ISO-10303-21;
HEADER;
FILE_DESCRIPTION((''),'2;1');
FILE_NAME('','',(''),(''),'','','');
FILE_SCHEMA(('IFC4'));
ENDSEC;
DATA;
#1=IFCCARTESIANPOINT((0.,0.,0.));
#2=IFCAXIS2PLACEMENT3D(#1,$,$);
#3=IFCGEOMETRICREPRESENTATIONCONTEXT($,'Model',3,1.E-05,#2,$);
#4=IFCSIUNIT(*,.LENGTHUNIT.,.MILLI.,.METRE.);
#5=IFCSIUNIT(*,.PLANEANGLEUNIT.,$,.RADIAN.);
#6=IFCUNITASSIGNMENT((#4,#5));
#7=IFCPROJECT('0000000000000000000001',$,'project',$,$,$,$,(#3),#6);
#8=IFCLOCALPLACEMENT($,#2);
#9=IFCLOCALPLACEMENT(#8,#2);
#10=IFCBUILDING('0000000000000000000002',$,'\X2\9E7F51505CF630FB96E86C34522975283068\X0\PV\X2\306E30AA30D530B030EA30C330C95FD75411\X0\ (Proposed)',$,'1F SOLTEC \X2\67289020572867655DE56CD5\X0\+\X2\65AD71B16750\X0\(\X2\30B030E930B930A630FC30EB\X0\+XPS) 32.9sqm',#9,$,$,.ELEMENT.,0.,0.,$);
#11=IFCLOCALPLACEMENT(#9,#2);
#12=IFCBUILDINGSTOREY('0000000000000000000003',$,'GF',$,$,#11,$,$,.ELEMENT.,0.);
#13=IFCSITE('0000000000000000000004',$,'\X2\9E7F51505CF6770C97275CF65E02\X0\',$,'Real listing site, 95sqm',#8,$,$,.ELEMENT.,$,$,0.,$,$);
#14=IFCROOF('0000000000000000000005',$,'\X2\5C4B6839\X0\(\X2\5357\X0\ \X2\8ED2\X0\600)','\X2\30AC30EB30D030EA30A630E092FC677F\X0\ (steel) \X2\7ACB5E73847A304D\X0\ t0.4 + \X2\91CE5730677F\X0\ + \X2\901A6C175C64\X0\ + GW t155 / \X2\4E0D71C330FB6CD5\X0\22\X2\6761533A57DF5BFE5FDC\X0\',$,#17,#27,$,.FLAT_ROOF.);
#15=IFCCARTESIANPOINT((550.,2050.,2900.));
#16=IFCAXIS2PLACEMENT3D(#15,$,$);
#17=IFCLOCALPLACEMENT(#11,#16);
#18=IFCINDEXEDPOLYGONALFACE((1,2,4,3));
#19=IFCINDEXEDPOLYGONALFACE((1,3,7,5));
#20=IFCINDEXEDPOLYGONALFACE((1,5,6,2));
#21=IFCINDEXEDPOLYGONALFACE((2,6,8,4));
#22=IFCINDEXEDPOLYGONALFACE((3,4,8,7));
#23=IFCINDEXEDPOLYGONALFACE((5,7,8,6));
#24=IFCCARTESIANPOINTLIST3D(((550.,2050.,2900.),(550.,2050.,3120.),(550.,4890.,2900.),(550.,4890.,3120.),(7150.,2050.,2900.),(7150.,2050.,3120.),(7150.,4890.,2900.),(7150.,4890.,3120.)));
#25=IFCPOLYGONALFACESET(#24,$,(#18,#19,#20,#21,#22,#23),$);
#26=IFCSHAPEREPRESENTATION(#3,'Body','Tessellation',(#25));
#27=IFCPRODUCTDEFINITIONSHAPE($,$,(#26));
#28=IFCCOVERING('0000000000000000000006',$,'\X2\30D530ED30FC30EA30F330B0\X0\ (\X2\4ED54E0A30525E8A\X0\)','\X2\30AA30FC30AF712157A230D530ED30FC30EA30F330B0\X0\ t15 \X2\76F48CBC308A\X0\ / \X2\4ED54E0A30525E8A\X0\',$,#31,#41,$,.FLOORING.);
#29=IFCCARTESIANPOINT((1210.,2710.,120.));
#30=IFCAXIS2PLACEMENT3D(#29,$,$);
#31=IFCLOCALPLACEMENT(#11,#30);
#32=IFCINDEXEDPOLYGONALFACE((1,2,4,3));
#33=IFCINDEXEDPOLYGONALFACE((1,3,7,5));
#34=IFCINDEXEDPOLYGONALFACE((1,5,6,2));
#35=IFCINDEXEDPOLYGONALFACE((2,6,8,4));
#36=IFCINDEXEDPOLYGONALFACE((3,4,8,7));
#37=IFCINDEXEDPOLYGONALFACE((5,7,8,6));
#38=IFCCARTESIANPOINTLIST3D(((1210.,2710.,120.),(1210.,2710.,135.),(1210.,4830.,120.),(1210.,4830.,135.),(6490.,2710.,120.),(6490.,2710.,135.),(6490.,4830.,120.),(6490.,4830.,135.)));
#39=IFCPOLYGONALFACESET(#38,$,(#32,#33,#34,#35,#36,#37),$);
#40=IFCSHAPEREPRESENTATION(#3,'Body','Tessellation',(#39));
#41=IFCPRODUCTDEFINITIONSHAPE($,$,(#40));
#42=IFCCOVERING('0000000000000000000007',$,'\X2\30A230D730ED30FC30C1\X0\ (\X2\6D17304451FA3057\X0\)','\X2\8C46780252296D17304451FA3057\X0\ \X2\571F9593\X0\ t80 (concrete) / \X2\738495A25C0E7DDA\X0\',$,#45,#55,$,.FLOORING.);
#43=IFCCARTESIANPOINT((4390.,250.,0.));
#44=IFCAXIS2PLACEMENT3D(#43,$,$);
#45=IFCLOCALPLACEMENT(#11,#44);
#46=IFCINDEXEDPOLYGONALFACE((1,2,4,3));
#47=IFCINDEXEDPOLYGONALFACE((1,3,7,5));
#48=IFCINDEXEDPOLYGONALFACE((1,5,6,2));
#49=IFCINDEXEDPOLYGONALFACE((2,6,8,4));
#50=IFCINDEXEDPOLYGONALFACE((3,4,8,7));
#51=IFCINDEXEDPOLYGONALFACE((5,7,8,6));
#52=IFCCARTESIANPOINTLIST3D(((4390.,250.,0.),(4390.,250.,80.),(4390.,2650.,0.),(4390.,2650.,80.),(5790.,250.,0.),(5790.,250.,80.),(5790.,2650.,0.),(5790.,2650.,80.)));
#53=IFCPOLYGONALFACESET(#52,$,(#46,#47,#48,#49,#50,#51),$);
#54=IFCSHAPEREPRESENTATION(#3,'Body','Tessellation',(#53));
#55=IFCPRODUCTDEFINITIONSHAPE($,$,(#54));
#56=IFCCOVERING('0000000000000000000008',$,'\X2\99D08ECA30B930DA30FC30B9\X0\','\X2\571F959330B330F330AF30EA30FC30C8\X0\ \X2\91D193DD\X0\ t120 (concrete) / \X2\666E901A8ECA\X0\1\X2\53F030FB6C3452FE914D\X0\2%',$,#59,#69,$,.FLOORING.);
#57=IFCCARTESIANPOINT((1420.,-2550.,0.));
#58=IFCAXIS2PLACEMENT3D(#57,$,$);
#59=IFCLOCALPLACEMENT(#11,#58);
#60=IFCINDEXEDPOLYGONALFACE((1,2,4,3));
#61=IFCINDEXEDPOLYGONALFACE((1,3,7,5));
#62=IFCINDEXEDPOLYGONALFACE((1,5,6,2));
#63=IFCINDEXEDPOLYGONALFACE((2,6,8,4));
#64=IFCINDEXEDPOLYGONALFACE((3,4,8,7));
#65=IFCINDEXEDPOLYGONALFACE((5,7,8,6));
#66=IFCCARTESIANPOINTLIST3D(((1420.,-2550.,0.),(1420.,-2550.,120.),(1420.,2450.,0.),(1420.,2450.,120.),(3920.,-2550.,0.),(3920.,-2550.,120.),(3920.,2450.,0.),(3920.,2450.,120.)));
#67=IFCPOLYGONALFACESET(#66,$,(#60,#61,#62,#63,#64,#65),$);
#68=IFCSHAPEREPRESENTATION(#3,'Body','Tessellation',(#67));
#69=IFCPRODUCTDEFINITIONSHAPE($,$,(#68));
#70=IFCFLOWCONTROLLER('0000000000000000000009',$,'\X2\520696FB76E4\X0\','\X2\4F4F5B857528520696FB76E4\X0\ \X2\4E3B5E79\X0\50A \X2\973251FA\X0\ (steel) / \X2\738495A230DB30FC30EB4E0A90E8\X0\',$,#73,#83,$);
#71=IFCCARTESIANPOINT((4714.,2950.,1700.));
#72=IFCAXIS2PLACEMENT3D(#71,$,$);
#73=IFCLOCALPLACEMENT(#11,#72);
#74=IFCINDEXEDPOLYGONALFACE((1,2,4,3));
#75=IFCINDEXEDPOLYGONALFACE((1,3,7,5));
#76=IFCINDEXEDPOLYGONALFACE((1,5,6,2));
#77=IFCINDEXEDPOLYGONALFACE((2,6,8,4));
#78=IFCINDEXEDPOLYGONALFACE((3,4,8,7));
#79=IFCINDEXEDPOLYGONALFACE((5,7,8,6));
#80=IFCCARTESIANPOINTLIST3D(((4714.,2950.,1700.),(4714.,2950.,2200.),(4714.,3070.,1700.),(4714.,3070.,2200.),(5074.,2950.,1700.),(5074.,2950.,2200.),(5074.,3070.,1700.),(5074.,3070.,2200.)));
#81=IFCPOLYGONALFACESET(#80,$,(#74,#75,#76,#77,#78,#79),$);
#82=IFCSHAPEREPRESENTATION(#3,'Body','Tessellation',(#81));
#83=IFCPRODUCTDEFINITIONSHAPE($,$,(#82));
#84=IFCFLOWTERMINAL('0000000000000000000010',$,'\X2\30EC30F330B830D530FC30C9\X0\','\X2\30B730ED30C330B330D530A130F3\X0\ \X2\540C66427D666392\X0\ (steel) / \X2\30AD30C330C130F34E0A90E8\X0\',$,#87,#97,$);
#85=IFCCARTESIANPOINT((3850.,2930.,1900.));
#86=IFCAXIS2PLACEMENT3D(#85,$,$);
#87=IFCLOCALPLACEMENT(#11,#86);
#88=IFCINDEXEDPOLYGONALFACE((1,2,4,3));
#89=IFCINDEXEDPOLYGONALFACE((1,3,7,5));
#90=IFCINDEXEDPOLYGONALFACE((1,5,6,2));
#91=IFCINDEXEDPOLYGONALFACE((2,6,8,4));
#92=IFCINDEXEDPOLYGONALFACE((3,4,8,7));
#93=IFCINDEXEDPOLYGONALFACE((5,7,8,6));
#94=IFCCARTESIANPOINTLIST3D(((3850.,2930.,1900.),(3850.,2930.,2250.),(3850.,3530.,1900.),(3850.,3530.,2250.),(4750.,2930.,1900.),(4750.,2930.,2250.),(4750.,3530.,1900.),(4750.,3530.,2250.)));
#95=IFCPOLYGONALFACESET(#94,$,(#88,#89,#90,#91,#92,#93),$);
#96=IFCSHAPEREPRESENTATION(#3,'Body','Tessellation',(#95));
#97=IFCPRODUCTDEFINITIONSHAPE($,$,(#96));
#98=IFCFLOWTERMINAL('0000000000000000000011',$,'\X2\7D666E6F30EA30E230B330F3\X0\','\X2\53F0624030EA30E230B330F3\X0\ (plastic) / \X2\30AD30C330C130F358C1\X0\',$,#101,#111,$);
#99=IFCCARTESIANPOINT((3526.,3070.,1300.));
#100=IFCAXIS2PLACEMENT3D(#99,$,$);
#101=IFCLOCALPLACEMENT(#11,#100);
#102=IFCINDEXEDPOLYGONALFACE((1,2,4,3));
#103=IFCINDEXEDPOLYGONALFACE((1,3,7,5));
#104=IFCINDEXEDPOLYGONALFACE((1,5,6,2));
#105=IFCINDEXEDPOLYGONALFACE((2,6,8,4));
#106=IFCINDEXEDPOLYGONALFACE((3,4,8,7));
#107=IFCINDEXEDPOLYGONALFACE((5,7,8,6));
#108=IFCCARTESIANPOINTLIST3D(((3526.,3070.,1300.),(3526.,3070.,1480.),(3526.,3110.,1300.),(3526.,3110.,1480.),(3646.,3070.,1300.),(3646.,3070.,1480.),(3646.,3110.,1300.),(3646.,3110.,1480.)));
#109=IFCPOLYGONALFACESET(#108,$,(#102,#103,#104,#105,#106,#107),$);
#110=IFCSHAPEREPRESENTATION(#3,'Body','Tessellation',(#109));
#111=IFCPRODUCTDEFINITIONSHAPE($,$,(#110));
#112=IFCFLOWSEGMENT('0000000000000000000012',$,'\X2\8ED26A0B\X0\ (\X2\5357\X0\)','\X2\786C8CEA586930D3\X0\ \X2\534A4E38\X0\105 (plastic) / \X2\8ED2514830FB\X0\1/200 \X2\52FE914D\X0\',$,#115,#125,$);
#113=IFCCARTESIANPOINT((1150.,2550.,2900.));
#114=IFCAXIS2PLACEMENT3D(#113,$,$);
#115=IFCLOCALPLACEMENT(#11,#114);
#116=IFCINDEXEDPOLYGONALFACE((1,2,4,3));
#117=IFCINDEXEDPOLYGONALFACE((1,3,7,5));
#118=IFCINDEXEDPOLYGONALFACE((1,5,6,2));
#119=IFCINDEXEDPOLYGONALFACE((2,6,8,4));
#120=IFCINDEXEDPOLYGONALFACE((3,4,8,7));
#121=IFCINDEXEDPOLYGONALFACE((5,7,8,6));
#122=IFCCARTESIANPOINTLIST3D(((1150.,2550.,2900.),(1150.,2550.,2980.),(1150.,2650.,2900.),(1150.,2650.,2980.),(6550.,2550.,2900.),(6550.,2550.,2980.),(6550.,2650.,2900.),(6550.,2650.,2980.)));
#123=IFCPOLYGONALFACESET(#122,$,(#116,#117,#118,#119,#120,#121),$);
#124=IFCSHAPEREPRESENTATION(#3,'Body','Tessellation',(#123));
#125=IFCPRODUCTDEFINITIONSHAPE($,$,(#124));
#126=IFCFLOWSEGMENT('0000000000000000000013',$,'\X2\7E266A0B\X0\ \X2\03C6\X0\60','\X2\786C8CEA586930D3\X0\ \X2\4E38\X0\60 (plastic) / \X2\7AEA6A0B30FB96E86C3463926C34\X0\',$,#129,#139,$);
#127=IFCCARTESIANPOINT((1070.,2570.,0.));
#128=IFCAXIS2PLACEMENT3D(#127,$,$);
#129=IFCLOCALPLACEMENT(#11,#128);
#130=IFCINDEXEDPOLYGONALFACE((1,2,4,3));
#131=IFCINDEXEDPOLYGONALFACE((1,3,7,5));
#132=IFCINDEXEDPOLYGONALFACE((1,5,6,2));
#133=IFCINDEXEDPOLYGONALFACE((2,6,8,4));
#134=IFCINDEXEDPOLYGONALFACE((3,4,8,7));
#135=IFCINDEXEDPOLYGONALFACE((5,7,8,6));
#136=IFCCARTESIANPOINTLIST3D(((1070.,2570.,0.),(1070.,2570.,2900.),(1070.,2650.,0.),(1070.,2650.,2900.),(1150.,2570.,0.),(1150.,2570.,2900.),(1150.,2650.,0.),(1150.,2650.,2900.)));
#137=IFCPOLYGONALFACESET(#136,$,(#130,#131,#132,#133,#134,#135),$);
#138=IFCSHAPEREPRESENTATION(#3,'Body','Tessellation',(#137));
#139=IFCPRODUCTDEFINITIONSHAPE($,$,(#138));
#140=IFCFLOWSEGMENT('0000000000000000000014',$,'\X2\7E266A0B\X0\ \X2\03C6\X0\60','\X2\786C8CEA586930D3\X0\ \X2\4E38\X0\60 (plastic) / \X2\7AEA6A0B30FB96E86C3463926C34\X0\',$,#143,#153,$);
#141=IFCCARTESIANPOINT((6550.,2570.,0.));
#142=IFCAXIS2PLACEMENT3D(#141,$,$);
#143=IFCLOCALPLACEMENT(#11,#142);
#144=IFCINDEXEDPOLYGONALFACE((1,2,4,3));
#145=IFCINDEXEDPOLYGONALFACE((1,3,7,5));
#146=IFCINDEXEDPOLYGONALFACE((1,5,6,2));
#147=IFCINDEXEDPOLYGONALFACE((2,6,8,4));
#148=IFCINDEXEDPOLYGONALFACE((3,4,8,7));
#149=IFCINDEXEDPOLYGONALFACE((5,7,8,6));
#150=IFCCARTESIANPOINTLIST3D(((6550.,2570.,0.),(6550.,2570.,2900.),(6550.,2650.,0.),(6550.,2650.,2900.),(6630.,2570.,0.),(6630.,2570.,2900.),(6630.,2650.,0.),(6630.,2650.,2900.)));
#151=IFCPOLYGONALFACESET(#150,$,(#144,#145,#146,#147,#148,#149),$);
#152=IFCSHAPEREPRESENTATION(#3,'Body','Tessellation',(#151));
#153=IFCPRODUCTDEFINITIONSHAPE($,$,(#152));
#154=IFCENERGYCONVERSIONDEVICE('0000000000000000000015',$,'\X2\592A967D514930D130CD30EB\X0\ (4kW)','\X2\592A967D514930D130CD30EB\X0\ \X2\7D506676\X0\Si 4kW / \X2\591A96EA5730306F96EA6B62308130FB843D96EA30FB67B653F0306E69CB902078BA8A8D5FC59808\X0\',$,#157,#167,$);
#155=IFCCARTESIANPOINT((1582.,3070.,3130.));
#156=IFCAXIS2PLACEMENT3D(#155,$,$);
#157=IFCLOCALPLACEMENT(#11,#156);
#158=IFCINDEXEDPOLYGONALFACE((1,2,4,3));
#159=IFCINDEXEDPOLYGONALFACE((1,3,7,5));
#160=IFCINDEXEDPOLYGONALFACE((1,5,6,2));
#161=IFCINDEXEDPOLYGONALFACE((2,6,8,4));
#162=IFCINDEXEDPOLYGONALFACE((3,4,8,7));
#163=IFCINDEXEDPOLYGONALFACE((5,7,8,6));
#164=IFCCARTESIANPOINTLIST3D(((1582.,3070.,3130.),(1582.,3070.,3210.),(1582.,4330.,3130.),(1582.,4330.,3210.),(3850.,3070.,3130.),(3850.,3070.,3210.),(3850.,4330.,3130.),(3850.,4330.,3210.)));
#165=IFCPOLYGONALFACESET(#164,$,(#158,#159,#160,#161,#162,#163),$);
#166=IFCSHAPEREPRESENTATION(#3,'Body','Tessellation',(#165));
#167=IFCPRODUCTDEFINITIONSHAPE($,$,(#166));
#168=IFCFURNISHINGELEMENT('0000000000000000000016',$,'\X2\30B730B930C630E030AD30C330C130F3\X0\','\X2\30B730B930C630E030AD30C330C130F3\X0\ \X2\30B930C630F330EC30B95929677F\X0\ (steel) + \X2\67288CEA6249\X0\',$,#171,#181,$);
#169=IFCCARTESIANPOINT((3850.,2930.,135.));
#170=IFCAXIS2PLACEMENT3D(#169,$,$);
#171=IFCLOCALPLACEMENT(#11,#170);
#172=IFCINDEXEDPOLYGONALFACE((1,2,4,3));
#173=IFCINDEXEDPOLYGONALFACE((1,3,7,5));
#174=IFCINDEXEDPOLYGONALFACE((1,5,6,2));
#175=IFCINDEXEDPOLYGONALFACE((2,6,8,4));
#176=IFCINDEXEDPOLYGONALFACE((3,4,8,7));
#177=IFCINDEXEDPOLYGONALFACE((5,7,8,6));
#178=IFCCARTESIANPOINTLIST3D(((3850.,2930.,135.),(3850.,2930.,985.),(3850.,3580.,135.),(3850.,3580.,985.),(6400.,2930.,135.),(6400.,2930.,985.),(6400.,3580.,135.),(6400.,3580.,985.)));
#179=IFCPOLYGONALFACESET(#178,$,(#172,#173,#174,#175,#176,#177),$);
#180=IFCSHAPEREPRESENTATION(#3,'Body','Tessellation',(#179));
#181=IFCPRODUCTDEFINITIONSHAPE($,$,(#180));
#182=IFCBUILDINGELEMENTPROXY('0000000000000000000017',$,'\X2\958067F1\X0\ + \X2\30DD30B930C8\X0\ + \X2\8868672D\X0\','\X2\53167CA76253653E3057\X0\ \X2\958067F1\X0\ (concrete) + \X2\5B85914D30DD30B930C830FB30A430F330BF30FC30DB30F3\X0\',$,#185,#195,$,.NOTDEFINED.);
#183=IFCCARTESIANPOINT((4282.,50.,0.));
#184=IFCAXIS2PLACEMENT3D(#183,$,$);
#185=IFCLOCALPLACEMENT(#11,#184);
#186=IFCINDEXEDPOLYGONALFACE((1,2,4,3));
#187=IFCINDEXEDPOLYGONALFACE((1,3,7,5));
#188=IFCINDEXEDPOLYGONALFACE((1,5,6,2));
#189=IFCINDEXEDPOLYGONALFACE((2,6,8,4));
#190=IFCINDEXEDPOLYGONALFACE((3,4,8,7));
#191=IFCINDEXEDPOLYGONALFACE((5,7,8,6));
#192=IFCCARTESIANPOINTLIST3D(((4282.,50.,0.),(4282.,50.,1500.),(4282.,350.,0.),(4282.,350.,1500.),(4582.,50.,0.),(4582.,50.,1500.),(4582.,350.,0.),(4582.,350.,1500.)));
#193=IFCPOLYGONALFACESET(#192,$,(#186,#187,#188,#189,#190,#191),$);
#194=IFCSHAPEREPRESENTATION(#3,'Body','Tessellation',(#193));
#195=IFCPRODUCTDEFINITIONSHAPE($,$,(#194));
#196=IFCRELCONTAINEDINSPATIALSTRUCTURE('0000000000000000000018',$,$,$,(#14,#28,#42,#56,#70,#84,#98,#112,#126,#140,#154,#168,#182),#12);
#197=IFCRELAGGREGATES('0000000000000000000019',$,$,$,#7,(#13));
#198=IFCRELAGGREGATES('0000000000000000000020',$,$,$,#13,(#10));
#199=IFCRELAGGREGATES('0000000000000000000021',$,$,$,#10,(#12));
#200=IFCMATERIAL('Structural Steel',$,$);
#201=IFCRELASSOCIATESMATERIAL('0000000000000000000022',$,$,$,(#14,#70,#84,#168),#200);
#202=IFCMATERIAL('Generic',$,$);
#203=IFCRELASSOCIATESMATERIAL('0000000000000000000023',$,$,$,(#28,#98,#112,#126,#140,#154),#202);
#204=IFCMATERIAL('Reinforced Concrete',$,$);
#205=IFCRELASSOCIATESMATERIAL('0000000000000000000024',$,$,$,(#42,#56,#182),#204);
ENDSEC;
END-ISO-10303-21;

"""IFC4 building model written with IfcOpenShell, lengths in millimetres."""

from ifc_helpers import new_model, si_unit, frame, frame_2d, origin, place, context, project, spatial, rectangle, extrude, material, element, save


model = new_model("IFC4")

# Units and contexts
model_context = context("Model", 3, precision=1e-05, world=origin())
ifc_project = project(units=[si_unit("LENGTHUNIT", "METRE", prefix="MILLI"), si_unit("PLANEANGLEUNIT", "RADIAN")], contexts=[model_context])

# Site, building, storey
site_placement = place(None, origin())
site = spatial("IfcSite", under=ifc_project, at=site_placement, Name="鹿児島県霧島市", ObjectType="Real listing site, 95sqm", CompositionType="ELEMENT", RefElevation=0.0)
building_placement = place(site_placement, origin())
building = spatial("IfcBuilding", under=site, at=building_placement, Name="鹿児島・雨水利用とPVのオフグリッド志向 (Proposed)", ObjectType="1F SOLTEC 木造在来工法+断熱材(グラスウール+XPS) 32.9sqm", CompositionType="ELEMENT", ElevationOfRefHeight=0.0, ElevationOfTerrain=0.0)
storey_placement = place(building_placement, origin())
storey = spatial("IfcBuildingStorey", under=building, at=storey_placement, Name="GF", CompositionType="ELEMENT", Elevation=0.0)

# Shared definitions
ifc_material_1 = material(Name="Reinforced Concrete")

# Roof
ifc_material_2 = material(Name="Structural Steel")
roof_placement = place(storey_placement, frame((550.0, 2050.0, 2900.0)))
element("IfcRoof", 1, at=roof_placement, inside=storey, material=ifc_material_2, Name="屋根(南 軒600)", Description="ガルバリウム鋼板 (steel) 立平葺き t0.4 + 野地板 + 通気層 + GW t155 / 不燃・法22条区域対応", PredefinedType="FLAT_ROOF", context=model_context, shape_type="SweptSolid", body=[
    extrude(rectangle(XDim=6600.0, YDim=2840.0, at=frame_2d((3300.0, 1420.0))), frame((550.0, 2050.0, 2900.0)), (0.0, 0.0, 1.0), 220.0),
])

# Coverings
ifc_material_3 = material(Name="Generic")
covering_1_placement = place(storey_placement, frame((1210.0, 2710.0, 120.0)))
element("IfcCovering", 2, at=covering_1_placement, inside=storey, material=ifc_material_3, Name="フローリング (仕上げ床)", Description="オーク無垢フローリング t15 直貼り / 仕上げ床", PredefinedType="FLOORING", context=model_context, shape_type="SweptSolid", body=[
    extrude(rectangle(XDim=5280.0, YDim=2120.0, at=frame_2d((2640.0, 1060.0))), frame((1210.0, 2710.0, 120.0)), (0.0, 0.0, 1.0), 15.0),
])
covering_2_placement = place(storey_placement, frame((4390.0, 250.0, 0.0)))
element("IfcCovering", 3, at=covering_2_placement, inside=storey, material=ifc_material_1, Name="アプローチ (洗い出し)", Description="豆砂利洗い出し 土間 t80 (concrete) / 玄関導線", PredefinedType="FLOORING", context=model_context, shape_type="SweptSolid", body=[
    extrude(rectangle(XDim=1400.0, YDim=2400.0, at=frame_2d((700.0, 1200.0))), frame((4390.0, 250.0, 0.0)), (0.0, 0.0, 1.0), 80.0),
])
covering_3_placement = place(storey_placement, frame((1420.0, -2550.0, 0.0)))
element("IfcCovering", 4, at=covering_3_placement, inside=storey, material=ifc_material_1, Name="駐車スペース", Description="土間コンクリート 金鏝 t120 (concrete) / 普通車1台・水勾配2%", PredefinedType="FLOORING", context=model_context, shape_type="SweptSolid", body=[
    extrude(rectangle(XDim=2500.0, YDim=5000.0, at=frame_2d((1250.0, 2500.0))), frame((1420.0, -2550.0, 0.0)), (0.0, 0.0, 1.0), 120.0),
])

# Flow controller
flow_controller_placement = place(storey_placement, frame((4714.0, 2950.0, 1700.0)))
element("IfcFlowController", 5, at=flow_controller_placement, inside=storey, material=ifc_material_2, Name="分電盤", Description="住宅用分電盤 主幹50A 露出 (steel) / 玄関ホール上部", context=model_context, shape_type="SweptSolid", body=[
    extrude(rectangle(XDim=360.0, YDim=120.0, at=frame_2d((180.0, 60.0))), frame((4714.0, 2950.0, 1700.0)), (0.0, 0.0, 1.0), 500.0),
])

# Flow terminals
flow_terminal_1_placement = place(storey_placement, frame((3850.0, 2930.0, 1900.0)))
element("IfcFlowTerminal", 6, at=flow_terminal_1_placement, inside=storey, material=ifc_material_2, Name="レンジフード", Description="シロッコファン 同時給排 (steel) / キッチン上部", context=model_context, shape_type="SweptSolid", body=[
    extrude(rectangle(XDim=900.0, YDim=600.0, at=frame_2d((450.0, 300.0))), frame((3850.0, 2930.0, 1900.0)), (0.0, 0.0, 1.0), 350.0),
])
flow_terminal_2_placement = place(storey_placement, frame((3526.0, 3070.0, 1300.0)))
element("IfcFlowTerminal", 7, at=flow_terminal_2_placement, inside=storey, material=ifc_material_3, Name="給湯リモコン", Description="台所リモコン (plastic) / キッチン壁", context=model_context, shape_type="SweptSolid", body=[
    extrude(rectangle(XDim=120.0, YDim=40.0, at=frame_2d((60.0, 20.0))), frame((3526.0, 3070.0, 1300.0)), (0.0, 0.0, 1.0), 180.0),
])

# Flow segments
flow_segment_1_placement = place(storey_placement, frame((1150.0, 2550.0, 2900.0)))
element("IfcFlowSegment", 8, at=flow_segment_1_placement, inside=storey, material=ifc_material_3, Name="軒樋 (南)", Description="硬質塩ビ 半丸105 (plastic) / 軒先・1/200 勾配", context=model_context, shape_type="SweptSolid", body=[
    extrude(rectangle(XDim=5400.0, YDim=100.0, at=frame_2d((2700.0, 50.0))), frame((1150.0, 2550.0, 2900.0)), (0.0, 0.0, 1.0), 80.0),
])
flow_segment_2_placement = place(storey_placement, frame((1070.0, 2570.0, 0.0)))
element("IfcFlowSegment", 9, at=flow_segment_2_placement, inside=storey, material=ifc_material_3, Name="縦樋 φ60", Description="硬質塩ビ 丸60 (plastic) / 竪樋・雨水排水", context=model_context, shape_type="SweptSolid", body=[
    extrude(rectangle(XDim=80.0, YDim=80.0, at=frame_2d((40.0, 40.0))), frame((1070.0, 2570.0, 0.0)), (0.0, 0.0, 1.0), 2900.0),
])
flow_segment_3_placement = place(storey_placement, frame((6550.0, 2570.0, 0.0)))
element("IfcFlowSegment", 10, at=flow_segment_3_placement, inside=storey, material=ifc_material_3, Name="縦樋 φ60", Description="硬質塩ビ 丸60 (plastic) / 竪樋・雨水排水", context=model_context, shape_type="SweptSolid", body=[
    extrude(rectangle(XDim=80.0, YDim=80.0, at=frame_2d((40.0, 40.0))), frame((6550.0, 2570.0, 0.0)), (0.0, 0.0, 1.0), 2900.0),
])

# Energy conversion device
energy_conversion_device_placement = place(storey_placement, frame((1582.0, 3070.0, 3130.0)))
element("IfcEnergyConversionDevice", 11, at=energy_conversion_device_placement, inside=storey, material=ifc_material_3, Name="太陽光パネル (4kW)", Description="太陽光パネル 結晶Si 4kW / 多雪地は雪止め・落雪・架台の構造確認必須", context=model_context, shape_type="SweptSolid", body=[
    extrude(rectangle(XDim=2268.0, YDim=1260.0, at=frame_2d((1134.0, 630.0))), frame((1582.0, 3070.0, 3130.0)), (0.0, 0.0, 1.0), 80.0),
])

# Furnishing element
furnishing_placement = place(storey_placement, frame((3850.0, 2930.0, 135.0)))
element("IfcFurnishingElement", 12, at=furnishing_placement, inside=storey, material=ifc_material_2, Name="システムキッチン", Description="システムキッチン ステンレス天板 (steel) + 木質扉", context=model_context, shape_type="SweptSolid", body=[
    extrude(rectangle(XDim=2550.0, YDim=650.0, at=frame_2d((1275.0, 325.0))), frame((3850.0, 2930.0, 135.0)), (0.0, 0.0, 1.0), 850.0),
])

# Building element proxy
proxy_placement = place(storey_placement, frame((4282.0, 50.0, 0.0)))
element("IfcBuildingElementProxy", 13, at=proxy_placement, inside=storey, material=ifc_material_1, Name="門柱 + ポスト + 表札", Description="化粧打放し 門柱 (concrete) + 宅配ポスト・インターホン", PredefinedType="NOTDEFINED", context=model_context, shape_type="SweptSolid", body=[
    extrude(rectangle(XDim=300.0, YDim=300.0, at=frame_2d((150.0, 150.0))), frame((4282.0, 50.0, 0.0)), (0.0, 0.0, 1.0), 1500.0),
])

save(model, "model.ifc")
